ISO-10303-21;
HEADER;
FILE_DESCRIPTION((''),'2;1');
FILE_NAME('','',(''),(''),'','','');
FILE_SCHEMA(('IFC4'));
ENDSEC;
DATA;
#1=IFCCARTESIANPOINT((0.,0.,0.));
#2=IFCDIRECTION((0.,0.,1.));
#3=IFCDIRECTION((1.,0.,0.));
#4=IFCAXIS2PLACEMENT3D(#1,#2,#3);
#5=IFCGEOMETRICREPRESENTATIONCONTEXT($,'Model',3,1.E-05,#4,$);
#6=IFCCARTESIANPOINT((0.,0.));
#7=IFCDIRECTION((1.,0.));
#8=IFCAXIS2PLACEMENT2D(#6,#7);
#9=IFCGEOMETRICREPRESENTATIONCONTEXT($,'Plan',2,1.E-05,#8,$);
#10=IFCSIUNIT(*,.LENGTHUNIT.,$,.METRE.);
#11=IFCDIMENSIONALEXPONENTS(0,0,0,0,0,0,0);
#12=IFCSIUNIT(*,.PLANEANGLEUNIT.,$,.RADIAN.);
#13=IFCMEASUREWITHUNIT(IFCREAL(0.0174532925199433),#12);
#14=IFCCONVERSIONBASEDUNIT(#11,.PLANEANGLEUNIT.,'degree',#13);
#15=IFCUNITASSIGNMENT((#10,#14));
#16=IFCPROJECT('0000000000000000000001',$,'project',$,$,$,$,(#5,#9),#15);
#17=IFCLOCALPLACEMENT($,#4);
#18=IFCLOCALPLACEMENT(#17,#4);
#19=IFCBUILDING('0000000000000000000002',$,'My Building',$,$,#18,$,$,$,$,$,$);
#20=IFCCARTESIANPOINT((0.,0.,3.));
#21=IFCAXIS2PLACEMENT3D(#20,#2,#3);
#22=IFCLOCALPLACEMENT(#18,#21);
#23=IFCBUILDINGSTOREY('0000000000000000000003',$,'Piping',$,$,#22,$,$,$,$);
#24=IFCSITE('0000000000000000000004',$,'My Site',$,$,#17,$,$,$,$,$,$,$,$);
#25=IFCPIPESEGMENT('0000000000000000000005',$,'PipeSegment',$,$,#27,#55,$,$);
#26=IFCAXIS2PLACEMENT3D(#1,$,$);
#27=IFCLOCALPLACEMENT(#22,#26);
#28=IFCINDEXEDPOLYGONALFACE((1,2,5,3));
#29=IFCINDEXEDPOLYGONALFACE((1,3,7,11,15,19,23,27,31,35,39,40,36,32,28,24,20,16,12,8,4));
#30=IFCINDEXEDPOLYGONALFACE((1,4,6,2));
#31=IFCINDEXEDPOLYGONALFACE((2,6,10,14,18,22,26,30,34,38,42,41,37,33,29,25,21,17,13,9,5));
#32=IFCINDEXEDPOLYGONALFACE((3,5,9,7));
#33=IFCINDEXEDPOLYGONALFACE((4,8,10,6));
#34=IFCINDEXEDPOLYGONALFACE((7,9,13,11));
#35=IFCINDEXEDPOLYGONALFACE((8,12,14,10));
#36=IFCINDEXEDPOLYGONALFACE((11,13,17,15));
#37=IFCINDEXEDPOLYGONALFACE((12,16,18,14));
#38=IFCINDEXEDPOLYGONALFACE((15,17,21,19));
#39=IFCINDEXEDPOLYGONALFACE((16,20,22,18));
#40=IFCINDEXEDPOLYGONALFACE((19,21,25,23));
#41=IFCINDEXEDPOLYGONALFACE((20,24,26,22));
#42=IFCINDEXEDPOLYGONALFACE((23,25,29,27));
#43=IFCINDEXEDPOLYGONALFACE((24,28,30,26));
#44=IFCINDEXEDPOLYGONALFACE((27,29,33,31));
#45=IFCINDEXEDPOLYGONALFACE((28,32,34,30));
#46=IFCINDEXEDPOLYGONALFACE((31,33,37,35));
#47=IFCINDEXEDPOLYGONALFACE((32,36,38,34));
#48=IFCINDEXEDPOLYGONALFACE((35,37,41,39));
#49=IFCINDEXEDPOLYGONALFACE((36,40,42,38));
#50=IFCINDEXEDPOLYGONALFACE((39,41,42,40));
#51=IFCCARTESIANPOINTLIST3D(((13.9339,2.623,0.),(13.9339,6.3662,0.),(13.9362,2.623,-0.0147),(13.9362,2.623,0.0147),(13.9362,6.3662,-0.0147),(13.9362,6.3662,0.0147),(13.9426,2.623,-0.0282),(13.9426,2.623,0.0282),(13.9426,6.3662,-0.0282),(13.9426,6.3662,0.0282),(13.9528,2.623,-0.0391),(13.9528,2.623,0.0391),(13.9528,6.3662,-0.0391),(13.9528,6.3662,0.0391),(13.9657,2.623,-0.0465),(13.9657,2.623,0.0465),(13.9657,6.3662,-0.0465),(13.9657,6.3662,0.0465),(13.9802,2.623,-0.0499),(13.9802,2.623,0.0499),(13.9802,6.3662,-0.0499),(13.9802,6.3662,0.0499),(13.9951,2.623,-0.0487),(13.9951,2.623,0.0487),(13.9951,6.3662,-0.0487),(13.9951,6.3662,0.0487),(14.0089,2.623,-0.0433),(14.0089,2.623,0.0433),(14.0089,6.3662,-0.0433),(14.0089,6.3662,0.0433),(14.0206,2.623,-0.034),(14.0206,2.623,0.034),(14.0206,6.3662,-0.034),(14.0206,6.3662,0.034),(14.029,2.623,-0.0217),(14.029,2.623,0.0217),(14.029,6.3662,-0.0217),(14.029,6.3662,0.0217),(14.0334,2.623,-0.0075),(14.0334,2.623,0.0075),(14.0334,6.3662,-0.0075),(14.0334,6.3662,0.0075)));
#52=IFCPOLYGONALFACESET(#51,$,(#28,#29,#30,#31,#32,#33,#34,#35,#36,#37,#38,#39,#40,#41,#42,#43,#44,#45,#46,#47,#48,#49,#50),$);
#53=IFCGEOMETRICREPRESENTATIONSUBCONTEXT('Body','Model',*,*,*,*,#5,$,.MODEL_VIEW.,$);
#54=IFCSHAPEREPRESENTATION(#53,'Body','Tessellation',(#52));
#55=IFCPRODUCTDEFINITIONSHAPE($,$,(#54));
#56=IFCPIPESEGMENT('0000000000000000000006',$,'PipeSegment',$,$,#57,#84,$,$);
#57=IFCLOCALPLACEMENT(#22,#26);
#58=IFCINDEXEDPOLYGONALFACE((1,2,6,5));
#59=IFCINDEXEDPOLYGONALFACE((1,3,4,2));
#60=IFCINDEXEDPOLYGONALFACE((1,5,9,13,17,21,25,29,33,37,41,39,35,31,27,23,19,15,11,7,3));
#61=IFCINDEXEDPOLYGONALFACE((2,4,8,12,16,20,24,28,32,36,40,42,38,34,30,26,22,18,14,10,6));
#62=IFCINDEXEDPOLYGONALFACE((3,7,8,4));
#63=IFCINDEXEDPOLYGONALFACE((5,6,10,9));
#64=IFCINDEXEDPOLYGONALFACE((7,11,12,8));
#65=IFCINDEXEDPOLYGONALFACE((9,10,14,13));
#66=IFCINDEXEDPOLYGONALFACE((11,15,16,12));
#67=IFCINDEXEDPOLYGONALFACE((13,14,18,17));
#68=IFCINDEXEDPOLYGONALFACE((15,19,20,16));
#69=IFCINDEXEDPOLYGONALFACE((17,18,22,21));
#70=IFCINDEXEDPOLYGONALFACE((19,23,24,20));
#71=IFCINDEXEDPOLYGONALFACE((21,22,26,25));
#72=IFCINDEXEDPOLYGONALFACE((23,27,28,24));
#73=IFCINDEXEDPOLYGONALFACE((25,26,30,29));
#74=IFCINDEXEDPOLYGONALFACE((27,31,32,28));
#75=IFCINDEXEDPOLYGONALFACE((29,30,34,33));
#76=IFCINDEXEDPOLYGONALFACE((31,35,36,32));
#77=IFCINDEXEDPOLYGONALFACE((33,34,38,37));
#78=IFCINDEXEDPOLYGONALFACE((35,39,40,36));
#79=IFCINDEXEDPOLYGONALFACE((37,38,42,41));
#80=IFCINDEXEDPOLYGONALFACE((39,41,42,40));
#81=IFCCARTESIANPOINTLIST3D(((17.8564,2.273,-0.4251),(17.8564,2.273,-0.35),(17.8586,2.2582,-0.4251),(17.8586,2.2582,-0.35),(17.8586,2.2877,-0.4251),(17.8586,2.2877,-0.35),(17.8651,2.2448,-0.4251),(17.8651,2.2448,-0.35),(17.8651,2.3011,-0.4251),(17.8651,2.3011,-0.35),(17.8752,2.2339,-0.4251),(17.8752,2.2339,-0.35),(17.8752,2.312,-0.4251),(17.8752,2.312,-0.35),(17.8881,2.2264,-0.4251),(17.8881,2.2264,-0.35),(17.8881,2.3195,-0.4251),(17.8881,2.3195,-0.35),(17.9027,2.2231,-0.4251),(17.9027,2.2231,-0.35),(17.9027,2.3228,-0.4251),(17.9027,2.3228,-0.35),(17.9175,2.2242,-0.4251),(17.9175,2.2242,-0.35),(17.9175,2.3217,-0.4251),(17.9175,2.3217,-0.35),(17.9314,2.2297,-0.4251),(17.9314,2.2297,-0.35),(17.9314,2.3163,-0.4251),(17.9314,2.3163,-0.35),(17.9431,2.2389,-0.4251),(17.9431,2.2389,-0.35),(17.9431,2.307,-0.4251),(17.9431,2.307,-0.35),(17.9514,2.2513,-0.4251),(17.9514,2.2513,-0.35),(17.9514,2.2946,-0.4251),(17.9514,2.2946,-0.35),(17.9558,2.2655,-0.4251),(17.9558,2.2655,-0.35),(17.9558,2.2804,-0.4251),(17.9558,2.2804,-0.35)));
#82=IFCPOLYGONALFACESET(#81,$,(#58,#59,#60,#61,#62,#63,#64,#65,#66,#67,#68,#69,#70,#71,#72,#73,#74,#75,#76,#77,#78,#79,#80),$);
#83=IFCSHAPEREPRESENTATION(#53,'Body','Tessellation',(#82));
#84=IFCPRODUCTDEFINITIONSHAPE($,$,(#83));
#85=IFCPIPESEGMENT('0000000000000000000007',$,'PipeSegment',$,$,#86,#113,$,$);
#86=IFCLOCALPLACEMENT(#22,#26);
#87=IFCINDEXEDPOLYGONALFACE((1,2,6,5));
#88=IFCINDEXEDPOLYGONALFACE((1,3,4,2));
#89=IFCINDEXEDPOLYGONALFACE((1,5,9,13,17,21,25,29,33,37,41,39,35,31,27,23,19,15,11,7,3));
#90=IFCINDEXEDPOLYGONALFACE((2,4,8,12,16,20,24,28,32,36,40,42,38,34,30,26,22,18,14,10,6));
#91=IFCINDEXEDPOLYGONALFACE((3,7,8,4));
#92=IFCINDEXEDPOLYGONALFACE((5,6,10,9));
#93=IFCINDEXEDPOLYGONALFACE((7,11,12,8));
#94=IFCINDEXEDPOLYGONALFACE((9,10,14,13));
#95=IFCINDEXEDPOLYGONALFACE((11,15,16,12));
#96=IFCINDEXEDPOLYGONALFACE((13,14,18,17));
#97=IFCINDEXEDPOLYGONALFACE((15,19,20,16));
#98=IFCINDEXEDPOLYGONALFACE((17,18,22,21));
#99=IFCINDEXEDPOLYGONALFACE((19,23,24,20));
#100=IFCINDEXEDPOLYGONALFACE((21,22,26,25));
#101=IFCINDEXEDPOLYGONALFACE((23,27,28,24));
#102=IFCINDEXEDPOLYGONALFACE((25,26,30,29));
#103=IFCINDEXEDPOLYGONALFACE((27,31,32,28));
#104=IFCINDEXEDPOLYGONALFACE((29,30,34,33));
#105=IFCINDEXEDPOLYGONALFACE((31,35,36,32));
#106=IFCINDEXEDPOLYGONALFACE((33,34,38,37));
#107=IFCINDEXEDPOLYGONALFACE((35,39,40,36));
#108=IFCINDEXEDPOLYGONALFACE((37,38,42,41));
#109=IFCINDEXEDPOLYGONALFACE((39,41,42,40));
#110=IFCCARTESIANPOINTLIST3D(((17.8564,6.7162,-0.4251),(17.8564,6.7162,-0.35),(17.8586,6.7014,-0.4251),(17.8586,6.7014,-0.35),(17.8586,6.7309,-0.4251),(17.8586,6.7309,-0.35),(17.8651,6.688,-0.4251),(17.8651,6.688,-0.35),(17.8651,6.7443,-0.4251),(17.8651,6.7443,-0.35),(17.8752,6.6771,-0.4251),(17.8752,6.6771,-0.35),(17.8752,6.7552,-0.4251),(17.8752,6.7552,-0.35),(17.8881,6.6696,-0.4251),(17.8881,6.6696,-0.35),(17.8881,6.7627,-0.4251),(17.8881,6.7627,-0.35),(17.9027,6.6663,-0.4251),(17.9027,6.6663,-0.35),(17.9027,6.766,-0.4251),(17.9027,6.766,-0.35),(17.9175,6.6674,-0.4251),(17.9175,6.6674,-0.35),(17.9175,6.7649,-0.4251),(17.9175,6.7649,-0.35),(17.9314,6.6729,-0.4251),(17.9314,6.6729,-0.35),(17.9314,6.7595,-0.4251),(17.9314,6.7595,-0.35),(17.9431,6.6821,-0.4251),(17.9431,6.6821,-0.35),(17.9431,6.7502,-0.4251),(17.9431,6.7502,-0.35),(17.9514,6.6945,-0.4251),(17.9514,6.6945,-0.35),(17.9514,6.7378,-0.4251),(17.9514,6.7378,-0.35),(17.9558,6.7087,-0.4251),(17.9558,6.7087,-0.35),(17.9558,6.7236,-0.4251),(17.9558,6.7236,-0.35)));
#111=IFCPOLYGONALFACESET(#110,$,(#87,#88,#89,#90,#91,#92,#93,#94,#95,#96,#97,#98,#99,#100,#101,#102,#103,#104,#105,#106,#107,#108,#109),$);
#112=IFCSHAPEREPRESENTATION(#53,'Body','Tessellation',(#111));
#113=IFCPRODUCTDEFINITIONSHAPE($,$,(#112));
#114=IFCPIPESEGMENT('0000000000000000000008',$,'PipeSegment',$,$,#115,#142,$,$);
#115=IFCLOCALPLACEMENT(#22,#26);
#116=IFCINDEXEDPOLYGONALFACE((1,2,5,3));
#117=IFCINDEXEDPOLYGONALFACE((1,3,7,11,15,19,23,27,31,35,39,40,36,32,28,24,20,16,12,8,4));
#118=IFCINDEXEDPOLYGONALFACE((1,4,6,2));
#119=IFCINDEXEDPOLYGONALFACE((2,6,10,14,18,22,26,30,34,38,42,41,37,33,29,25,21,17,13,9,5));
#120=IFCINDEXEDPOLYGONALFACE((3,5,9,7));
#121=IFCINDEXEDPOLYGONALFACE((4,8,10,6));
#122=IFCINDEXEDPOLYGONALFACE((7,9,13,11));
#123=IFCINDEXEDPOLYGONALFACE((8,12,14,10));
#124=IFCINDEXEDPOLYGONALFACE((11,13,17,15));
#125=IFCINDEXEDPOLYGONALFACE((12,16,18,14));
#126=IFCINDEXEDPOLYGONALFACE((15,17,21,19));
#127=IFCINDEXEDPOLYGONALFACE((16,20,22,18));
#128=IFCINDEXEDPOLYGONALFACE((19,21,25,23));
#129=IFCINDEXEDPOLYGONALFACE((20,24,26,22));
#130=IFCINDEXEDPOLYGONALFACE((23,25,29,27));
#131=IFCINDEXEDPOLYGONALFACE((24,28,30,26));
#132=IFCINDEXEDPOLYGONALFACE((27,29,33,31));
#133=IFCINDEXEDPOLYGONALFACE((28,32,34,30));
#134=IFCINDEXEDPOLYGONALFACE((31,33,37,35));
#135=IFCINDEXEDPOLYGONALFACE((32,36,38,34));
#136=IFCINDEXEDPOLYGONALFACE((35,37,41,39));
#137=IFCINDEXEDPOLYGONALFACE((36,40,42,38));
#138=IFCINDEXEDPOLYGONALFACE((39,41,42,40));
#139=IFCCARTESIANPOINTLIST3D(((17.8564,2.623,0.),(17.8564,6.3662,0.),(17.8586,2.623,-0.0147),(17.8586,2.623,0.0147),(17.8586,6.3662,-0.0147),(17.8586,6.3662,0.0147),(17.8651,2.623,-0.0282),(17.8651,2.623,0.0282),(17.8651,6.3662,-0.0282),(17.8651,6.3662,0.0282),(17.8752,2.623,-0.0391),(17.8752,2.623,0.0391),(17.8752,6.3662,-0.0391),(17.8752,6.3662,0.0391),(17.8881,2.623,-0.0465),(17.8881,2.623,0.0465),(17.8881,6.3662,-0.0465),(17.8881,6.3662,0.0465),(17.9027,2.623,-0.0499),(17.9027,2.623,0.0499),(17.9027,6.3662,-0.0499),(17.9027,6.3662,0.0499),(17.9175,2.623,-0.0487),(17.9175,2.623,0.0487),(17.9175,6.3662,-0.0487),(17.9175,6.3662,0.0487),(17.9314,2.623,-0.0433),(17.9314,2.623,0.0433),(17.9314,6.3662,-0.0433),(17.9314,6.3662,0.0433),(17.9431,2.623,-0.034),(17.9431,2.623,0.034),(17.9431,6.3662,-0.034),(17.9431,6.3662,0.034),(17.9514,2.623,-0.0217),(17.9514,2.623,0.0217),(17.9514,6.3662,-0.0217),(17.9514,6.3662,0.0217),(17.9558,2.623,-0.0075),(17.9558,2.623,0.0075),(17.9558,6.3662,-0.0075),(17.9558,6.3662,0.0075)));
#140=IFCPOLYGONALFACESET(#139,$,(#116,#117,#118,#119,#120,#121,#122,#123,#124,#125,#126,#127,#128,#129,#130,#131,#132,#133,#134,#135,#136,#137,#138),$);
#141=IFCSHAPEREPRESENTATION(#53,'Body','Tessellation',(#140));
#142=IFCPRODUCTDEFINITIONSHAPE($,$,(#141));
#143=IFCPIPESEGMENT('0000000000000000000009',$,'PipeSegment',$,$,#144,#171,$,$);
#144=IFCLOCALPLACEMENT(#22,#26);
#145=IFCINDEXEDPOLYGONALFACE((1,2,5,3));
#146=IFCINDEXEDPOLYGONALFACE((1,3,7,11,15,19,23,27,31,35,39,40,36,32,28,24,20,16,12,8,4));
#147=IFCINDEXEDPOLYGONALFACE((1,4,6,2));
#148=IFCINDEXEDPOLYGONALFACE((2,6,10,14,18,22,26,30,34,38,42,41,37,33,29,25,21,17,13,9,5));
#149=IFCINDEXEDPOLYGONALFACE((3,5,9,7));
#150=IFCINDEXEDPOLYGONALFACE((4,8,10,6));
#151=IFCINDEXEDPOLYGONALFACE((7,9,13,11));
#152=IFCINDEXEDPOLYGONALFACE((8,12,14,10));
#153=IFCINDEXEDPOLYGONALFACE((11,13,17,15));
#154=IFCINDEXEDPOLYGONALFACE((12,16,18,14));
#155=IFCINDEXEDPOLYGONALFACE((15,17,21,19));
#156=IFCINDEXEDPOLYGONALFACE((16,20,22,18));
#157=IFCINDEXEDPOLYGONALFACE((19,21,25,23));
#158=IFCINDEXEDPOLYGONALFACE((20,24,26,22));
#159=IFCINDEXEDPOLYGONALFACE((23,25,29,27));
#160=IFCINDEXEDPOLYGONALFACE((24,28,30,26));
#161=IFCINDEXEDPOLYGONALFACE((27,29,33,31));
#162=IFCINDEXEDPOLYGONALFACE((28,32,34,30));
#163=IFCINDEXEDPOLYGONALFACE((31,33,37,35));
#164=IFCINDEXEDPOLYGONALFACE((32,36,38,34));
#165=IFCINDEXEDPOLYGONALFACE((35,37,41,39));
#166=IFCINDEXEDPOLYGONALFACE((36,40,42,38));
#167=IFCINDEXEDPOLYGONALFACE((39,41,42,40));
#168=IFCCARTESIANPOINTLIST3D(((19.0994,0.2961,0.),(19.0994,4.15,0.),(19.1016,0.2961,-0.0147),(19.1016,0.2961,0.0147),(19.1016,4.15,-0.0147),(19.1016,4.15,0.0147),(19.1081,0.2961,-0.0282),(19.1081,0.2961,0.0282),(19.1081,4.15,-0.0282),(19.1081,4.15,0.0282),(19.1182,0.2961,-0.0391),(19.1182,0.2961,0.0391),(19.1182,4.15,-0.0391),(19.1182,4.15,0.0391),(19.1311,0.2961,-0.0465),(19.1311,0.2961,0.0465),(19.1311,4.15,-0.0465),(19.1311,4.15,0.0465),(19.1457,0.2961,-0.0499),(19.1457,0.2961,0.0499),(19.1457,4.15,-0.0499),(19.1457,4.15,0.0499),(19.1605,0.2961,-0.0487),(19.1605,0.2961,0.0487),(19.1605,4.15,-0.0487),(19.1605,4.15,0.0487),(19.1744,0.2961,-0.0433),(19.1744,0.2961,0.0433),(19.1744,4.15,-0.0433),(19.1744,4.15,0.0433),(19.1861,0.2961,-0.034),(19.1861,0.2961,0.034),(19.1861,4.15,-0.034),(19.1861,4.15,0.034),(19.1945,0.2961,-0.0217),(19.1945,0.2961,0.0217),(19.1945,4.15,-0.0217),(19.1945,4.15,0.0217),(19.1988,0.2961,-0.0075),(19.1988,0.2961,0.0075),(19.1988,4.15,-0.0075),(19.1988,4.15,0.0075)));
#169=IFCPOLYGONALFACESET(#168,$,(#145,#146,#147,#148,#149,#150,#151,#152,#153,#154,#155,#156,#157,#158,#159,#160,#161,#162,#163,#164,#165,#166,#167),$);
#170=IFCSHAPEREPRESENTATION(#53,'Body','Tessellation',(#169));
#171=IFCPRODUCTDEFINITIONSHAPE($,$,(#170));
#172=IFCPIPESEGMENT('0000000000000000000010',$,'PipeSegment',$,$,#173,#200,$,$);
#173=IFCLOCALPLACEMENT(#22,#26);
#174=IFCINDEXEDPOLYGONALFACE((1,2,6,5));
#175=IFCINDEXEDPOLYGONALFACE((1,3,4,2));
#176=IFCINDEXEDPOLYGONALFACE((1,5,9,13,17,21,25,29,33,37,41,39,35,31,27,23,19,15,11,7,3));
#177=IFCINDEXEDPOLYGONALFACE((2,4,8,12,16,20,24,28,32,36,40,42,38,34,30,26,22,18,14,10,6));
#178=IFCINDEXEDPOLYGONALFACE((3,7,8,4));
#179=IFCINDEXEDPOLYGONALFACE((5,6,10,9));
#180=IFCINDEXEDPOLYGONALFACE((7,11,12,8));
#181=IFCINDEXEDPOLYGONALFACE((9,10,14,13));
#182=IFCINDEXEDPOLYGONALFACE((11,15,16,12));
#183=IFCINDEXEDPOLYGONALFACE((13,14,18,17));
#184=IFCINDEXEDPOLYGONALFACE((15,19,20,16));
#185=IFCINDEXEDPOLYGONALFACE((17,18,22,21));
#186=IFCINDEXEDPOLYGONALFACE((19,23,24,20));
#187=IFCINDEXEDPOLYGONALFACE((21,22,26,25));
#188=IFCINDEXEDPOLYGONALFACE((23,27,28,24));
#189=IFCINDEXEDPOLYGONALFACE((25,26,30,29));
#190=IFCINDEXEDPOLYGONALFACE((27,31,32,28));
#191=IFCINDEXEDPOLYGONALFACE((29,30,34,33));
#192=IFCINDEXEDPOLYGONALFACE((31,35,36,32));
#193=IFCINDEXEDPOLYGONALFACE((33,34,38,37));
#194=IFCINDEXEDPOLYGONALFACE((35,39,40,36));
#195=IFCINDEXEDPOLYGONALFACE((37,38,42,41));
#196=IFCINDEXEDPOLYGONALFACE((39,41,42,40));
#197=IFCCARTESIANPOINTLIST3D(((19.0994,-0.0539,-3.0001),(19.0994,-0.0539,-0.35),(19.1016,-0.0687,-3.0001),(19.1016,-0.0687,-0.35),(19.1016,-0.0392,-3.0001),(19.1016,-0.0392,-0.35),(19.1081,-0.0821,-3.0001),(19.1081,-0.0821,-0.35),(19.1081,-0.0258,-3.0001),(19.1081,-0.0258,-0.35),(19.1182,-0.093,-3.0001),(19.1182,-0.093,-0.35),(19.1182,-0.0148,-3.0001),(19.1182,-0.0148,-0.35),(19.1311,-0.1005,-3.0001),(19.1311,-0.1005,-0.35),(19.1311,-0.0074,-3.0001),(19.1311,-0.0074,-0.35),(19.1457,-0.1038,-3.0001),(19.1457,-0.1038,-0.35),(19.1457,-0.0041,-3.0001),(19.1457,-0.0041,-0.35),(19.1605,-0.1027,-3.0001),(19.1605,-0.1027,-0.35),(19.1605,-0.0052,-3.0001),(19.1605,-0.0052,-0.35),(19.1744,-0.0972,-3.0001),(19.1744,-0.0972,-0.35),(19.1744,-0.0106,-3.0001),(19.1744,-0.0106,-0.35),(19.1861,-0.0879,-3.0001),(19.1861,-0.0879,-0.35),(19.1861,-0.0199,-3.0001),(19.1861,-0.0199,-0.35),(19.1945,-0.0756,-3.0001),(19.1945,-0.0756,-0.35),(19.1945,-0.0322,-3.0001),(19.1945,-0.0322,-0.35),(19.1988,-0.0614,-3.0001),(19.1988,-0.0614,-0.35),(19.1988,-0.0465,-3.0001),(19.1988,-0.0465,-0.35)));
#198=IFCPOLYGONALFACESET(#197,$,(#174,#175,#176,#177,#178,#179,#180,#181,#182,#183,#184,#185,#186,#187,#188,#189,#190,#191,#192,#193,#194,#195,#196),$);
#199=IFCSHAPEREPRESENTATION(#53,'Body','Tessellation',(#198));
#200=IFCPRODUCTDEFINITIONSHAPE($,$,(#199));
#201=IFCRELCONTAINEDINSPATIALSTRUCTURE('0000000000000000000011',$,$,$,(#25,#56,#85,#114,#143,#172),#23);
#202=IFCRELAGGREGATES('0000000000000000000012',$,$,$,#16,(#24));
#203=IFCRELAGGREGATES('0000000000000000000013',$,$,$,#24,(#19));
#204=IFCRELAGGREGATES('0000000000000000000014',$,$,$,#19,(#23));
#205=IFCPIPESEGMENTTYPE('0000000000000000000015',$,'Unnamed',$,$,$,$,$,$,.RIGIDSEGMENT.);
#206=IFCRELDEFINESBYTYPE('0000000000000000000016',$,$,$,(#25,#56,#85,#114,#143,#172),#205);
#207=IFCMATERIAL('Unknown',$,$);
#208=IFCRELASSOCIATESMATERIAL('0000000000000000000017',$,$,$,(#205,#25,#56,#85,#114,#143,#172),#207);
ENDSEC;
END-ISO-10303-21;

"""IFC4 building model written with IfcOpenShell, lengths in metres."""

from ifc_helpers import new_model, entity, si_unit, converted_unit, frame, origin_with_axes, origin_2d_with_axis, place, context, subcontext, project, spatial, circle, extrude, material, material_profile, profile_set, profile_usage, type_object, element, save


model = new_model("IFC4")

# Units and contexts
model_context = context("Model", 3, precision=1e-05, world=origin_with_axes())
plan_context = context("Plan", 2, precision=1e-05, world=origin_2d_with_axis())
body_context = subcontext(model_context, "Body", "Model", "MODEL_VIEW")
ifc_project = project(units=[si_unit("LENGTHUNIT", "METRE"), converted_unit("PLANEANGLEUNIT", "degree", entity("IfcReal", 0.0174532925199433), si_unit("PLANEANGLEUNIT", "RADIAN"), dimensions=[0, 0, 0, 0, 0, 0, 0])], contexts=[model_context, plan_context])

# Site, building, storey
site_placement = place(None, origin_with_axes())
site = spatial("IfcSite", under=ifc_project, at=site_placement, Name="My Site")
building_placement = place(site_placement, origin_with_axes())
building = spatial("IfcBuilding", under=site, at=building_placement, Name="My Building")
storey_placement = place(building_placement, frame((0.0, 0.0, 3.0), z_axis=(0.0, 0.0, 1.0), x_axis=(1.0, 0.0, 0.0)))
storey = spatial("IfcBuildingStorey", under=building, at=storey_placement, Name="Piping")

# Pipe segments
ifc_material = material(Name="Unknown")
ifc_material_profile = material_profile(ifc_material, circle(Radius=0.05))
ifc_profile_set = profile_set([ifc_material_profile])
pipe_segment_type = type_object("IfcPipeSegmentType", Name="Unnamed", PredefinedType="RIGIDSEGMENT", material=ifc_profile_set)
ifc_profile_usage_1 = profile_usage(ifc_profile_set, cardinal=5)
pipe_segment_1_placement = place(storey_placement, frame((13.9839, 2.623, 0.0), z_axis=(0.0, 1.0, 0.0), x_axis=(-1.0, 0.0, 0.0)))
element("IfcPipeSegment", 1, at=pipe_segment_1_placement, inside=storey, type_object=pipe_segment_type, material=ifc_profile_usage_1, Name="PipeSegment", context=body_context, shape_type="SweptSolid", body=[
    extrude(circle(Radius=0.05), origin_with_axes(), (0.0, 0.0, 1.0), 3.7432),
])
ifc_profile_usage_2 = profile_usage(ifc_profile_set, cardinal=5)
pipe_segment_2_placement = place(storey_placement, frame((17.9064, 2.273, -0.35), z_axis=(0.0, 0.0, -1.0), x_axis=(-1.0, 0.0, 0.0)))
element("IfcPipeSegment", 2, at=pipe_segment_2_placement, inside=storey, type_object=pipe_segment_type, material=ifc_profile_usage_2, Name="PipeSegment", context=body_context, shape_type="SweptSolid", body=[
    extrude(circle(Radius=0.05), origin_with_axes(), (0.0, 0.0, 1.0), 0.0751),
])
ifc_profile_usage_3 = profile_usage(ifc_profile_set, cardinal=5)
pipe_segment_3_placement = place(storey_placement, frame((17.9064, 6.7162, -0.35), z_axis=(0.0, 0.0, -1.0), x_axis=(-1.0, 0.0, 0.0)))
element("IfcPipeSegment", 3, at=pipe_segment_3_placement, inside=storey, type_object=pipe_segment_type, material=ifc_profile_usage_3, Name="PipeSegment", context=body_context, shape_type="SweptSolid", body=[
    extrude(circle(Radius=0.05), origin_with_axes(), (0.0, 0.0, 1.0), 0.0751),
])
ifc_profile_usage_4 = profile_usage(ifc_profile_set, cardinal=5)
pipe_segment_4_placement = place(storey_placement, frame((17.9064, 2.623, 0.0), z_axis=(0.0, 1.0, 0.0), x_axis=(-1.0, 0.0, 0.0)))
element("IfcPipeSegment", 4, at=pipe_segment_4_placement, inside=storey, type_object=pipe_segment_type, material=ifc_profile_usage_4, Name="PipeSegment", context=body_context, shape_type="SweptSolid", body=[
    extrude(circle(Radius=0.05), origin_with_axes(), (0.0, 0.0, 1.0), 3.7432),
])
ifc_profile_usage_5 = profile_usage(ifc_profile_set, cardinal=5)
pipe_segment_5_placement = place(storey_placement, frame((19.1494, 0.2961, 0.0), z_axis=(0.0, 1.0, 0.0), x_axis=(-1.0, 0.0, 0.0)))
element("IfcPipeSegment", 5, at=pipe_segment_5_placement, inside=storey, type_object=pipe_segment_type, material=ifc_profile_usage_5, Name="PipeSegment", context=body_context, shape_type="SweptSolid", body=[
    extrude(circle(Radius=0.05), origin_with_axes(), (0.0, 0.0, 1.0), 3.8539),
])
ifc_profile_usage_6 = profile_usage(ifc_profile_set, cardinal=5)
pipe_segment_6_placement = place(storey_placement, frame((19.1494, -0.0539, -0.35), z_axis=(0.0, 0.0, -1.0), x_axis=(-1.0, 0.0, 0.0)))
element("IfcPipeSegment", 6, at=pipe_segment_6_placement, inside=storey, type_object=pipe_segment_type, material=ifc_profile_usage_6, Name="PipeSegment", context=body_context, shape_type="SweptSolid", body=[
    extrude(circle(Radius=0.05), origin_with_axes(), (0.0, 0.0, 1.0), 2.6501),
])

save(model, "model.ifc")
